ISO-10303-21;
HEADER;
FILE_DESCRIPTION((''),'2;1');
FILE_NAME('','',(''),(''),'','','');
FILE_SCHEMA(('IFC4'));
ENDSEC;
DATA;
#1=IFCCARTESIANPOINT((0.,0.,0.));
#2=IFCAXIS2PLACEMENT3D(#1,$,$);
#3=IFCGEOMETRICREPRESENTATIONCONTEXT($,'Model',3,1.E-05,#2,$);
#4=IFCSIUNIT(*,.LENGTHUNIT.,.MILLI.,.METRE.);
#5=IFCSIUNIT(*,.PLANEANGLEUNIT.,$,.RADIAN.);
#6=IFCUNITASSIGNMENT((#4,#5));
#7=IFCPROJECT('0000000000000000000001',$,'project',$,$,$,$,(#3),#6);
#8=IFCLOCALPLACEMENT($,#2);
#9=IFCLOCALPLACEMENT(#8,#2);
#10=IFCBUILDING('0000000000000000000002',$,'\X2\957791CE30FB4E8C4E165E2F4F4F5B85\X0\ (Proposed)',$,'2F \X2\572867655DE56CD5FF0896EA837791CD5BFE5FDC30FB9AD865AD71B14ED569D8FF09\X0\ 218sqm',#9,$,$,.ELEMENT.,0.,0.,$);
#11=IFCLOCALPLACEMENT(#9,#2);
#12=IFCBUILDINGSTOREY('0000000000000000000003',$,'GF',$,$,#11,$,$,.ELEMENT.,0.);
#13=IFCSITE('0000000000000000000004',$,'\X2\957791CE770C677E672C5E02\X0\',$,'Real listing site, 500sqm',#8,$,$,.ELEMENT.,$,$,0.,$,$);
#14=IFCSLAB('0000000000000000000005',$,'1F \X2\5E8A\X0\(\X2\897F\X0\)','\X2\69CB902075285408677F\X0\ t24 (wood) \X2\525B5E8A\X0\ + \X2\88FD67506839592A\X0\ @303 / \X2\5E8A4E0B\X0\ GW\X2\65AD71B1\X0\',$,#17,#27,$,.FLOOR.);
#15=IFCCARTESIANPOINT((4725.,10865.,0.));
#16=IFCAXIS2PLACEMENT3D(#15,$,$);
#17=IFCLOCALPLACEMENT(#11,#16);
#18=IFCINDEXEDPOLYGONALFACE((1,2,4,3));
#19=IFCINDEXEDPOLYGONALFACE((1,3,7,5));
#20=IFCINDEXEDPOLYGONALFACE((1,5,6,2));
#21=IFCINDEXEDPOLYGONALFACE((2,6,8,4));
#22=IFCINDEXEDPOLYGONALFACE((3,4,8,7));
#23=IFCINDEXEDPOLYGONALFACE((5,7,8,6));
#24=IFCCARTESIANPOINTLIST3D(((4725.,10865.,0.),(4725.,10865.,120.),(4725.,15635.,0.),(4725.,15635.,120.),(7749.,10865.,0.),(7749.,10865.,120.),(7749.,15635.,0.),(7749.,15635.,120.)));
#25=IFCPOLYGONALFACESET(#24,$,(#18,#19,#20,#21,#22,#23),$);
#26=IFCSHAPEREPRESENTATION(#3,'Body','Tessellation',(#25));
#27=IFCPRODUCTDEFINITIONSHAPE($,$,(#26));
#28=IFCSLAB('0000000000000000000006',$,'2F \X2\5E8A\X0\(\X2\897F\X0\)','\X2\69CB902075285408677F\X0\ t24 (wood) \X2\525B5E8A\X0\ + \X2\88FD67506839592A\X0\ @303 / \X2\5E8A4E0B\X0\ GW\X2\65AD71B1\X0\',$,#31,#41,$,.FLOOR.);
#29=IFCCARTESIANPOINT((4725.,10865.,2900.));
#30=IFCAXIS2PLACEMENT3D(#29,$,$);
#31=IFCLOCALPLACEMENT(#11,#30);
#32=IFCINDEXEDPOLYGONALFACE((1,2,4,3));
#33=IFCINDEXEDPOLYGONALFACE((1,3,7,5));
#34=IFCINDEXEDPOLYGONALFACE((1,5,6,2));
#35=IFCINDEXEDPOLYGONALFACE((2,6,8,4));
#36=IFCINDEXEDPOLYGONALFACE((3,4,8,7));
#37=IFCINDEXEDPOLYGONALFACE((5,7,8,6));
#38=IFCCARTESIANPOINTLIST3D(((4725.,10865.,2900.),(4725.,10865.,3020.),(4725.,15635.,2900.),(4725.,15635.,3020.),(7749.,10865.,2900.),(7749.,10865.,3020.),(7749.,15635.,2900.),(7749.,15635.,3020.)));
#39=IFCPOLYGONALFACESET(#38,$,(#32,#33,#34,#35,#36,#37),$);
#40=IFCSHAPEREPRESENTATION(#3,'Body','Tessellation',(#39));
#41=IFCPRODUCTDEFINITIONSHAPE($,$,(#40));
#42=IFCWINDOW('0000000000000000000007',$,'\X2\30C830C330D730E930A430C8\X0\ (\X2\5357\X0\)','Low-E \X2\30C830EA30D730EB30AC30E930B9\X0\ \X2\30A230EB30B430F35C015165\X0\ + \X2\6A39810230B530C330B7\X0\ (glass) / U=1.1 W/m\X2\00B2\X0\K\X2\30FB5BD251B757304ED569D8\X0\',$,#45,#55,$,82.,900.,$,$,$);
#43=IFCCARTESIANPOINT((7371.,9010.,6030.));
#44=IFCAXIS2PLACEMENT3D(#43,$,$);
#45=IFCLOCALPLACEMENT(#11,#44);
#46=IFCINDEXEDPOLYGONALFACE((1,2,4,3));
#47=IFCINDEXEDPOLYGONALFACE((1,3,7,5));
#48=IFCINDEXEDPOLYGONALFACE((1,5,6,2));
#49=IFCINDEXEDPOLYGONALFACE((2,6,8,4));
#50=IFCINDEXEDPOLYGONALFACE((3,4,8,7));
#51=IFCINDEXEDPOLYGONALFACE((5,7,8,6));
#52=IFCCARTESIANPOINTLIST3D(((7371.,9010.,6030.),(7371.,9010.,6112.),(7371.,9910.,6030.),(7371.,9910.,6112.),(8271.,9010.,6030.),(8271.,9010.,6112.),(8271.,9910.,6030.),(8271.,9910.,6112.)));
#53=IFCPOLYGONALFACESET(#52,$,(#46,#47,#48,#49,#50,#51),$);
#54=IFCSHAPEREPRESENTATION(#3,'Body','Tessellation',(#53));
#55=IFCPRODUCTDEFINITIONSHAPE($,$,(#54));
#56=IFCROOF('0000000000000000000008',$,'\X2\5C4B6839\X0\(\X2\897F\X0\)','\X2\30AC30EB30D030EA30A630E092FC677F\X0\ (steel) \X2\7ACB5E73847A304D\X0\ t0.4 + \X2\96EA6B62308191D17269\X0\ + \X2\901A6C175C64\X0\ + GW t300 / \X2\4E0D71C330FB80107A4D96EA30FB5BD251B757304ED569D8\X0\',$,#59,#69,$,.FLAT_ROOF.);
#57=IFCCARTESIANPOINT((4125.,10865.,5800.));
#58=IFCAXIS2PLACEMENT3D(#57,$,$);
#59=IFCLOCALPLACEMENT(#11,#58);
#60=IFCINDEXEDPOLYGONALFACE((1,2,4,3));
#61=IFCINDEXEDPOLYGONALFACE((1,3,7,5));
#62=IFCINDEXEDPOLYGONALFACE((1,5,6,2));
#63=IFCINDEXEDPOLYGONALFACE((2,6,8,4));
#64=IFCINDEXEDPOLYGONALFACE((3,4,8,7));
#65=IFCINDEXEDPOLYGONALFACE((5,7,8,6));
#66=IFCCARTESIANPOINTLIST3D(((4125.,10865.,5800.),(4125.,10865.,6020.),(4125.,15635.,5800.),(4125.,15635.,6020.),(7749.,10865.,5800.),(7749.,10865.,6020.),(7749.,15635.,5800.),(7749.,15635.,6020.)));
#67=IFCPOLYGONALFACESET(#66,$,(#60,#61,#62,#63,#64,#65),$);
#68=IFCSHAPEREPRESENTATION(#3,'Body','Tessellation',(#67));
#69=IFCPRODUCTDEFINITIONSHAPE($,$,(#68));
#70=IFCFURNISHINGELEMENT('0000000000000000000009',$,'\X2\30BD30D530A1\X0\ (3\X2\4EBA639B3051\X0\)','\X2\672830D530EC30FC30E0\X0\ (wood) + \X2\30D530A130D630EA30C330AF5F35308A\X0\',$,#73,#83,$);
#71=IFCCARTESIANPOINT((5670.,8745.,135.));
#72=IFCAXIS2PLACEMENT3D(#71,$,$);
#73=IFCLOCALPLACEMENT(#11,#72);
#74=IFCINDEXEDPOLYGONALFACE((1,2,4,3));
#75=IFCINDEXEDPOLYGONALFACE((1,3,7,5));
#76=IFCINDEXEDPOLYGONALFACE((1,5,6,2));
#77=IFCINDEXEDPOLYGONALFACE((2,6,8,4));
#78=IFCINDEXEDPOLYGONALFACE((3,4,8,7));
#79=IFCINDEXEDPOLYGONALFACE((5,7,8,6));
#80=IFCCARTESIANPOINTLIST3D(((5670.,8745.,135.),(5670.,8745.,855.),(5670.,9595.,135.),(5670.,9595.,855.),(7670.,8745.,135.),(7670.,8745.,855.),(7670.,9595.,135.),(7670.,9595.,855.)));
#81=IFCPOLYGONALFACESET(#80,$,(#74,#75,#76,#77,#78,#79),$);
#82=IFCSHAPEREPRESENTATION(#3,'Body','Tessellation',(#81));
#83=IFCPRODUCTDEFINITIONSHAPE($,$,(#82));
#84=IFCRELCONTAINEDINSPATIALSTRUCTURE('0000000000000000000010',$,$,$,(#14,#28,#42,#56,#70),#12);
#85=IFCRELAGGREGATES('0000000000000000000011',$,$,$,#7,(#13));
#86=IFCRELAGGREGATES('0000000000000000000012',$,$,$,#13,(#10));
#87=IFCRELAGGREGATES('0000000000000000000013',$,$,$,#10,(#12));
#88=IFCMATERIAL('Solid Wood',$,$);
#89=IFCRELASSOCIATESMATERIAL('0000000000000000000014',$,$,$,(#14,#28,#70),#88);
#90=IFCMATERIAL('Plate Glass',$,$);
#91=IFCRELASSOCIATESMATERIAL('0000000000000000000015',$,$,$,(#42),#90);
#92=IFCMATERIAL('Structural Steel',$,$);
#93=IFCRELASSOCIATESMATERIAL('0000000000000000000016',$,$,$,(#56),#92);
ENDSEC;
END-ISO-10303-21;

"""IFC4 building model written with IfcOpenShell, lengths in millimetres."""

from ifc_helpers import new_model, si_unit, frame, frame_2d, origin, place, context, project, spatial, rectangle, extrude, material, element, save


model = new_model("IFC4")

# Units and contexts
model_context = context("Model", 3, precision=1e-05, world=origin())
ifc_project = project(units=[si_unit("LENGTHUNIT", "METRE", prefix="MILLI"), si_unit("PLANEANGLEUNIT", "RADIAN")], contexts=[model_context])

# Site, building, storey
site_placement = place(None, origin())
site = spatial("IfcSite", under=ifc_project, at=site_placement, Name="長野県松本市", ObjectType="Real listing site, 500sqm", CompositionType="ELEMENT", RefElevation=0.0)
building_placement = place(site_placement, origin())
building = spatial("IfcBuilding", under=site, at=building_placement, Name="長野・二世帯住宅 (Proposed)", ObjectType="2F 在来工法（雪荷重対応・高断熱仕様） 218sqm", CompositionType="ELEMENT", ElevationOfRefHeight=0.0, ElevationOfTerrain=0.0)
storey_placement = place(building_placement, origin())
storey = spatial("IfcBuildingStorey", under=building, at=storey_placement, Name="GF", CompositionType="ELEMENT", Elevation=0.0)

# Shared definitions
ifc_material_1 = material(Name="Solid Wood")

# Slabs
slab_1_placement = place(storey_placement, frame((4725.0, 10865.0, 0.0)))
element("IfcSlab", 1, at=slab_1_placement, inside=storey, material=ifc_material_1, Name="1F 床(西)", Description="構造用合板 t24 (wood) 剛床 + 製材根太 @303 / 床下 GW断熱", PredefinedType="FLOOR", context=model_context, shape_type="SweptSolid", body=[
    extrude(rectangle(XDim=3024.0, YDim=4770.0, at=frame_2d((1512.0, 2385.0))), frame((4725.0, 10865.0, 0.0)), (0.0, 0.0, 1.0), 120.0),
])
slab_2_placement = place(storey_placement, frame((4725.0, 10865.0, 2900.0)))
element("IfcSlab", 2, at=slab_2_placement, inside=storey, material=ifc_material_1, Name="2F 床(西)", Description="構造用合板 t24 (wood) 剛床 + 製材根太 @303 / 床下 GW断熱", PredefinedType="FLOOR", context=model_context, shape_type="SweptSolid", body=[
    extrude(rectangle(XDim=3024.0, YDim=4770.0, at=frame_2d((1512.0, 2385.0))), frame((4725.0, 10865.0, 2900.0)), (0.0, 0.0, 1.0), 120.0),
])

# Window
ifc_material_2 = material(Name="Plate Glass")
window_placement = place(storey_placement, frame((7371.0, 9010.0, 6030.0)))
element("IfcWindow", 3, at=window_placement, inside=storey, material=ifc_material_2, Name="トップライト (南)", Description="Low-E トリプルガラス アルゴン封入 + 樹脂サッシ (glass) / U=1.1 W/m²K・寒冷地仕様", OverallHeight=82.0, OverallWidth=900.0, context=model_context, shape_type="SweptSolid", body=[
    extrude(rectangle(XDim=900.0, YDim=900.0, at=frame_2d((450.0, 450.0))), frame((7371.0, 9010.0, 6030.0)), (0.0, 0.0, 1.0), 82.0),
])

# Roof
ifc_material_3 = material(Name="Structural Steel")
for number, where, name in (
    (4, (4125.0, 10865.0, 5800.0), "屋根(西)"),
):
    element("IfcRoof", number, at=place(storey_placement, frame(where)), inside=storey, material=ifc_material_3, Name=name, Description="ガルバリウム鋼板 (steel) 立平葺き t0.4 + 雪止め金物 + 通気層 + GW t300 / 不燃・耐積雪・寒冷地仕様", PredefinedType="FLAT_ROOF", context=model_context, shape_type="SweptSolid", body=[
        extrude(rectangle(XDim=3624.0, YDim=4770.0, at=frame_2d((1812.0, 2385.0))), frame((4125.0, 10865.0, 5800.0)), (0.0, 0.0, 1.0), 220.0),
    ])

# Furnishing element
furnishing_placement = place(storey_placement, frame((5670.0, 8745.0, 135.0)))
element("IfcFurnishingElement", 5, at=furnishing_placement, inside=storey, material=ifc_material_1, Name="ソファ (3人掛け)", Description="木フレーム (wood) + ファブリック張り", context=model_context, shape_type="SweptSolid", body=[
    extrude(rectangle(XDim=2000.0, YDim=850.0, at=frame_2d((1000.0, 425.0))), frame((5670.0, 8745.0, 135.0)), (0.0, 0.0, 1.0), 720.0),
])

save(model, "model.ifc")
